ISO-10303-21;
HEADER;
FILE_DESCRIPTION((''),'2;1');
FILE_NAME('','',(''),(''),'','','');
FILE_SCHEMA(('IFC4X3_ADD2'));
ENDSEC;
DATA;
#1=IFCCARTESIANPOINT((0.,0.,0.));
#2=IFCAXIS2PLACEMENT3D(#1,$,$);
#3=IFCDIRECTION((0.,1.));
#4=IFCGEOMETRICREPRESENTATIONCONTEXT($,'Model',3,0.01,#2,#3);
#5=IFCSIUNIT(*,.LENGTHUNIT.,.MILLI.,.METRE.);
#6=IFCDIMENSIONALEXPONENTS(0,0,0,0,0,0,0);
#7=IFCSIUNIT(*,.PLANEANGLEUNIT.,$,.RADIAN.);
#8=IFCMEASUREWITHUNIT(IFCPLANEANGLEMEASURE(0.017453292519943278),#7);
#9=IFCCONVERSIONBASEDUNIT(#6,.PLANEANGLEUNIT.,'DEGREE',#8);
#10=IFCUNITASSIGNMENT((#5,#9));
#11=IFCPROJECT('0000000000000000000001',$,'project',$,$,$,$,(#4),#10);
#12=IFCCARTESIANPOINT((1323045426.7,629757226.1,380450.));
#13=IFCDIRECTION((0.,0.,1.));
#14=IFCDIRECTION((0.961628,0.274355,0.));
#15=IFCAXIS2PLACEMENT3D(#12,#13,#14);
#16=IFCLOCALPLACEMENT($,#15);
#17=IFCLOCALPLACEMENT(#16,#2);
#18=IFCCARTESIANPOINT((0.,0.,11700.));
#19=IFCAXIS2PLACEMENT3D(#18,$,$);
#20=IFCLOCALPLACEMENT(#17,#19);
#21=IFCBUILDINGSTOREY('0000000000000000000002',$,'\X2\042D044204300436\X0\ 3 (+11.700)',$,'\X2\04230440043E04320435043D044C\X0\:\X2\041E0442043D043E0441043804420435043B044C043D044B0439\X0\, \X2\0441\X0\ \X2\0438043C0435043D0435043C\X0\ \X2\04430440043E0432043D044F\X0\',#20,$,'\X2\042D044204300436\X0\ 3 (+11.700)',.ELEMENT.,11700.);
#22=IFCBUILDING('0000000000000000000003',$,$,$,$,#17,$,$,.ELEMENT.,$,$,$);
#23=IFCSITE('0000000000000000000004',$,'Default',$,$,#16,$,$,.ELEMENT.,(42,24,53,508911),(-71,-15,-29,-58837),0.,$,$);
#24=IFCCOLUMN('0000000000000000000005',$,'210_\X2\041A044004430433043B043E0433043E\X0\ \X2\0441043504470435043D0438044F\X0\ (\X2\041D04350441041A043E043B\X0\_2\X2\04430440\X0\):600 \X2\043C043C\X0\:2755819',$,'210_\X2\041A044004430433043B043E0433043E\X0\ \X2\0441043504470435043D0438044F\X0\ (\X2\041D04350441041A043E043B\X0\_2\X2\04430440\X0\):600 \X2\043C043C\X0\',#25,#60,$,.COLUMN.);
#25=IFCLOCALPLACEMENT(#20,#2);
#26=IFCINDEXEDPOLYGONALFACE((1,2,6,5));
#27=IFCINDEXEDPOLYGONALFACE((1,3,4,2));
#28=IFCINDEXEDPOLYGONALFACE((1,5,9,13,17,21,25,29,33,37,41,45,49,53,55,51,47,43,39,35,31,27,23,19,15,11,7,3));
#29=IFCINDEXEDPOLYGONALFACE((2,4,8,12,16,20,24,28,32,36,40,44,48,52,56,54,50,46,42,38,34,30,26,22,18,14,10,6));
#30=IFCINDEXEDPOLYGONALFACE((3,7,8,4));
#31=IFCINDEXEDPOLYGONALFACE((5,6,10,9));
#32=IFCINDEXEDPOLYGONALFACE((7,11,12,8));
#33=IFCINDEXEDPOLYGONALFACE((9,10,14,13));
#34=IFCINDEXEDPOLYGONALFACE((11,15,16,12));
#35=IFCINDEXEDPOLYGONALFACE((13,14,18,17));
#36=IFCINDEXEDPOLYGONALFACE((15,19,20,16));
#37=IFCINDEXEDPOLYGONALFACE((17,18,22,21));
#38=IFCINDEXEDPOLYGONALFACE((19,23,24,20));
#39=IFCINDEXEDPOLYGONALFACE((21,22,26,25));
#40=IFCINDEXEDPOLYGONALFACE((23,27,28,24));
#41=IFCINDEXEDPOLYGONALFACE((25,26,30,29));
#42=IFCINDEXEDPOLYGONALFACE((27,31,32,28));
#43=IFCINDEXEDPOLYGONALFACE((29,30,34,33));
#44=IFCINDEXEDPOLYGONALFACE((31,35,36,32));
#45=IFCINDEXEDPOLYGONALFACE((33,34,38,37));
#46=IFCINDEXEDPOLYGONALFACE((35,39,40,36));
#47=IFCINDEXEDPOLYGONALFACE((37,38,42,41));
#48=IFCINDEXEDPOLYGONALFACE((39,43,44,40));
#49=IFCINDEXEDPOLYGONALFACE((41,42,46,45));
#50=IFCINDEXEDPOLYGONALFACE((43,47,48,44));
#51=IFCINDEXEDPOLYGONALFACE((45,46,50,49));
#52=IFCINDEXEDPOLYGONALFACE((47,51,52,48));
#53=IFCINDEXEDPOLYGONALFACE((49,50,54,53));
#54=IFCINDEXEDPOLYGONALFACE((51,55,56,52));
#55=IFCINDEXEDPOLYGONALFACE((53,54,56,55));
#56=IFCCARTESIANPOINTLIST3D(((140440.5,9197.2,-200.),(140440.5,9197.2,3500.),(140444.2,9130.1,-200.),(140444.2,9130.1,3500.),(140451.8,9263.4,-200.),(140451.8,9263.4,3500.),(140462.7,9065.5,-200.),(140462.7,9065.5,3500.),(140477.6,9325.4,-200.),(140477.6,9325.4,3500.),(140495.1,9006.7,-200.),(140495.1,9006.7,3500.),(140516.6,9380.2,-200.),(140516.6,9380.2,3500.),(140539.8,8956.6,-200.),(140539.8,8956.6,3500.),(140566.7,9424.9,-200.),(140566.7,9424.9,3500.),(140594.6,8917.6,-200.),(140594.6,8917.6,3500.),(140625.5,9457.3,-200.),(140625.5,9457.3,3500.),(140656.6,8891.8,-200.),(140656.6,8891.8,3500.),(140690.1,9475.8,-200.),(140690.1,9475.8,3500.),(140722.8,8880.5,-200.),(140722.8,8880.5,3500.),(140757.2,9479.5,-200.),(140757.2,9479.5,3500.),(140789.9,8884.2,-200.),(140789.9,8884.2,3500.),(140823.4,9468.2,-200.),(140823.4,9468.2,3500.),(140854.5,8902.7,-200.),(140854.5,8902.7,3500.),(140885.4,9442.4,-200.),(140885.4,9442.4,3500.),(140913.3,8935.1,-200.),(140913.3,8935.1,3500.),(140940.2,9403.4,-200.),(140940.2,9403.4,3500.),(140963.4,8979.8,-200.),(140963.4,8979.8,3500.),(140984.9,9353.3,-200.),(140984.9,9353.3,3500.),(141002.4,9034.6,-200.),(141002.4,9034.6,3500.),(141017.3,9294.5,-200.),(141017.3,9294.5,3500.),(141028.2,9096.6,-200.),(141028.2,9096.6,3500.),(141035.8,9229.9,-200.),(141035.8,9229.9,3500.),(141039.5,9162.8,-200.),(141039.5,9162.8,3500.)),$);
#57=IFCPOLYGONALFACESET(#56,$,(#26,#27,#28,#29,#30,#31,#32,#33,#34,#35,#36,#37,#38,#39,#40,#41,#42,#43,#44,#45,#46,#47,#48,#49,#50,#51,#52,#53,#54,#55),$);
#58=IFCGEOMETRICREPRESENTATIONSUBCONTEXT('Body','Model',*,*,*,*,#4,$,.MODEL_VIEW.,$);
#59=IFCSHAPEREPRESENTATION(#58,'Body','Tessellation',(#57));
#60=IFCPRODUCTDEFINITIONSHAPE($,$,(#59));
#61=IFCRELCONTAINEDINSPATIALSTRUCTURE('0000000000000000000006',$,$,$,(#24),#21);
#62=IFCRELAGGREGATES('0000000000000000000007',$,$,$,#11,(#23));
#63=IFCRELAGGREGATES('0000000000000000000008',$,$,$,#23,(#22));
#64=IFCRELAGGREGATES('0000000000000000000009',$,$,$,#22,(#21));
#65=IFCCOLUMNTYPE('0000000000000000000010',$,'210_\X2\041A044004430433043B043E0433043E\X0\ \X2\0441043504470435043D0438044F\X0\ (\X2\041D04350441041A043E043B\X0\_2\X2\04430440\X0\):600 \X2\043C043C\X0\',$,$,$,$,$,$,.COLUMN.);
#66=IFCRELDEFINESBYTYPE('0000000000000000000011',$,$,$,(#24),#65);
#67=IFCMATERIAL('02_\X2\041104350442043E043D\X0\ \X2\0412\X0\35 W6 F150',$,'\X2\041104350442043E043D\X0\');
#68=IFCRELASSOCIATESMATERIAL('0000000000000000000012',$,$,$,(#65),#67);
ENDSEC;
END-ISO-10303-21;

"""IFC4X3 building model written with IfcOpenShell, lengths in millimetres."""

from ifc_helpers import new_model, entity, si_unit, converted_unit, direction, frame, origin, origin_2d_with_axis, place, context, subcontext, project, spatial, circle, extrude, source, transform, mapped, material, material_profile, profile_set, type_object, type_shapes, element, save


model = new_model("IFC4X3")

# Units and contexts
model_context = context("Model", 3, precision=0.01, world=origin(), true_north=direction((0.0, 1.0)))
body_context = subcontext(model_context, "Body", "Model", "MODEL_VIEW")
ifc_project = project(units=[si_unit("LENGTHUNIT", "METRE", prefix="MILLI"), converted_unit("PLANEANGLEUNIT", "DEGREE", entity("IfcPlaneAngleMeasure", 0.017453292519943278), si_unit("PLANEANGLEUNIT", "RADIAN"), dimensions=[0, 0, 0, 0, 0, 0, 0])], contexts=[model_context])

# Site, building, storey
site_placement = place(None, frame((1323045426.7, 629757226.1, 380450.0), z_axis=(0.0, 0.0, 1.0), x_axis=(0.961628, 0.274355, 0.0)))
site = spatial("IfcSite", under=ifc_project, at=site_placement, Name="Default", CompositionType="ELEMENT", RefLatitude=(42, 24, 53, 508911), RefLongitude=(-71, -15, -29, -58837), RefElevation=0.0)
building_placement = place(site_placement, origin())
building = spatial("IfcBuilding", under=site, at=building_placement, CompositionType="ELEMENT")
storey_placement = place(building_placement, frame((0.0, 0.0, 11700.0)))
storey = spatial("IfcBuildingStorey", under=building, at=storey_placement, Name="Этаж 3 (+11.700)", ObjectType="Уровень:Относительный, с именем уровня", LongName="Этаж 3 (+11.700)", CompositionType="ELEMENT", Elevation=11700.0)

# Column
ifc_material = material(Name="02_Бетон В35 W6 F150", Category="Бетон")
ifc_material_profile_1 = material_profile(ifc_material, circle(Radius=300.0, at=origin_2d_with_axis()), Name="600 мм")
ifc_profile_set_1 = profile_set([ifc_material_profile_1], Name="600 мм")
column_type_1 = type_object("IfcColumnType", Name="210_Круглого сечения (НесКол_2ур):600 мм", PredefinedType="COLUMN", material=ifc_profile_set_1)
shared_shape_1 = source(origin(), body_context, "Body", "SweptSolid", [
    extrude(circle(Radius=300.0, at=origin_2d_with_axis()), frame((140740.0, 9180.0, 11500.0), z_axis=(0.0, 0.0, 1.0), x_axis=(0.87462, -0.48481, 0.0)), (0.0, 0.0, 1.0), 3700.0),
])
type_shapes(column_type_1, [shared_shape_1])
column_1_placement = place(storey_placement, frame((0.0, 0.0, -11700.0)))
element("IfcColumn", 1, at=column_1_placement, inside=storey, type_object=column_type_1, Name="210_Круглого сечения (НесКол_2ур):600 мм:2755819", ObjectType="210_Круглого сечения (НесКол_2ур):600 мм", PredefinedType="COLUMN", context=body_context, shape_type="MappedRepresentation", body=[
    mapped(shared_shape_1, transform((0.0, 0.0, 0.0), scale=1.0)),
])

save(model, "model.ifc")
